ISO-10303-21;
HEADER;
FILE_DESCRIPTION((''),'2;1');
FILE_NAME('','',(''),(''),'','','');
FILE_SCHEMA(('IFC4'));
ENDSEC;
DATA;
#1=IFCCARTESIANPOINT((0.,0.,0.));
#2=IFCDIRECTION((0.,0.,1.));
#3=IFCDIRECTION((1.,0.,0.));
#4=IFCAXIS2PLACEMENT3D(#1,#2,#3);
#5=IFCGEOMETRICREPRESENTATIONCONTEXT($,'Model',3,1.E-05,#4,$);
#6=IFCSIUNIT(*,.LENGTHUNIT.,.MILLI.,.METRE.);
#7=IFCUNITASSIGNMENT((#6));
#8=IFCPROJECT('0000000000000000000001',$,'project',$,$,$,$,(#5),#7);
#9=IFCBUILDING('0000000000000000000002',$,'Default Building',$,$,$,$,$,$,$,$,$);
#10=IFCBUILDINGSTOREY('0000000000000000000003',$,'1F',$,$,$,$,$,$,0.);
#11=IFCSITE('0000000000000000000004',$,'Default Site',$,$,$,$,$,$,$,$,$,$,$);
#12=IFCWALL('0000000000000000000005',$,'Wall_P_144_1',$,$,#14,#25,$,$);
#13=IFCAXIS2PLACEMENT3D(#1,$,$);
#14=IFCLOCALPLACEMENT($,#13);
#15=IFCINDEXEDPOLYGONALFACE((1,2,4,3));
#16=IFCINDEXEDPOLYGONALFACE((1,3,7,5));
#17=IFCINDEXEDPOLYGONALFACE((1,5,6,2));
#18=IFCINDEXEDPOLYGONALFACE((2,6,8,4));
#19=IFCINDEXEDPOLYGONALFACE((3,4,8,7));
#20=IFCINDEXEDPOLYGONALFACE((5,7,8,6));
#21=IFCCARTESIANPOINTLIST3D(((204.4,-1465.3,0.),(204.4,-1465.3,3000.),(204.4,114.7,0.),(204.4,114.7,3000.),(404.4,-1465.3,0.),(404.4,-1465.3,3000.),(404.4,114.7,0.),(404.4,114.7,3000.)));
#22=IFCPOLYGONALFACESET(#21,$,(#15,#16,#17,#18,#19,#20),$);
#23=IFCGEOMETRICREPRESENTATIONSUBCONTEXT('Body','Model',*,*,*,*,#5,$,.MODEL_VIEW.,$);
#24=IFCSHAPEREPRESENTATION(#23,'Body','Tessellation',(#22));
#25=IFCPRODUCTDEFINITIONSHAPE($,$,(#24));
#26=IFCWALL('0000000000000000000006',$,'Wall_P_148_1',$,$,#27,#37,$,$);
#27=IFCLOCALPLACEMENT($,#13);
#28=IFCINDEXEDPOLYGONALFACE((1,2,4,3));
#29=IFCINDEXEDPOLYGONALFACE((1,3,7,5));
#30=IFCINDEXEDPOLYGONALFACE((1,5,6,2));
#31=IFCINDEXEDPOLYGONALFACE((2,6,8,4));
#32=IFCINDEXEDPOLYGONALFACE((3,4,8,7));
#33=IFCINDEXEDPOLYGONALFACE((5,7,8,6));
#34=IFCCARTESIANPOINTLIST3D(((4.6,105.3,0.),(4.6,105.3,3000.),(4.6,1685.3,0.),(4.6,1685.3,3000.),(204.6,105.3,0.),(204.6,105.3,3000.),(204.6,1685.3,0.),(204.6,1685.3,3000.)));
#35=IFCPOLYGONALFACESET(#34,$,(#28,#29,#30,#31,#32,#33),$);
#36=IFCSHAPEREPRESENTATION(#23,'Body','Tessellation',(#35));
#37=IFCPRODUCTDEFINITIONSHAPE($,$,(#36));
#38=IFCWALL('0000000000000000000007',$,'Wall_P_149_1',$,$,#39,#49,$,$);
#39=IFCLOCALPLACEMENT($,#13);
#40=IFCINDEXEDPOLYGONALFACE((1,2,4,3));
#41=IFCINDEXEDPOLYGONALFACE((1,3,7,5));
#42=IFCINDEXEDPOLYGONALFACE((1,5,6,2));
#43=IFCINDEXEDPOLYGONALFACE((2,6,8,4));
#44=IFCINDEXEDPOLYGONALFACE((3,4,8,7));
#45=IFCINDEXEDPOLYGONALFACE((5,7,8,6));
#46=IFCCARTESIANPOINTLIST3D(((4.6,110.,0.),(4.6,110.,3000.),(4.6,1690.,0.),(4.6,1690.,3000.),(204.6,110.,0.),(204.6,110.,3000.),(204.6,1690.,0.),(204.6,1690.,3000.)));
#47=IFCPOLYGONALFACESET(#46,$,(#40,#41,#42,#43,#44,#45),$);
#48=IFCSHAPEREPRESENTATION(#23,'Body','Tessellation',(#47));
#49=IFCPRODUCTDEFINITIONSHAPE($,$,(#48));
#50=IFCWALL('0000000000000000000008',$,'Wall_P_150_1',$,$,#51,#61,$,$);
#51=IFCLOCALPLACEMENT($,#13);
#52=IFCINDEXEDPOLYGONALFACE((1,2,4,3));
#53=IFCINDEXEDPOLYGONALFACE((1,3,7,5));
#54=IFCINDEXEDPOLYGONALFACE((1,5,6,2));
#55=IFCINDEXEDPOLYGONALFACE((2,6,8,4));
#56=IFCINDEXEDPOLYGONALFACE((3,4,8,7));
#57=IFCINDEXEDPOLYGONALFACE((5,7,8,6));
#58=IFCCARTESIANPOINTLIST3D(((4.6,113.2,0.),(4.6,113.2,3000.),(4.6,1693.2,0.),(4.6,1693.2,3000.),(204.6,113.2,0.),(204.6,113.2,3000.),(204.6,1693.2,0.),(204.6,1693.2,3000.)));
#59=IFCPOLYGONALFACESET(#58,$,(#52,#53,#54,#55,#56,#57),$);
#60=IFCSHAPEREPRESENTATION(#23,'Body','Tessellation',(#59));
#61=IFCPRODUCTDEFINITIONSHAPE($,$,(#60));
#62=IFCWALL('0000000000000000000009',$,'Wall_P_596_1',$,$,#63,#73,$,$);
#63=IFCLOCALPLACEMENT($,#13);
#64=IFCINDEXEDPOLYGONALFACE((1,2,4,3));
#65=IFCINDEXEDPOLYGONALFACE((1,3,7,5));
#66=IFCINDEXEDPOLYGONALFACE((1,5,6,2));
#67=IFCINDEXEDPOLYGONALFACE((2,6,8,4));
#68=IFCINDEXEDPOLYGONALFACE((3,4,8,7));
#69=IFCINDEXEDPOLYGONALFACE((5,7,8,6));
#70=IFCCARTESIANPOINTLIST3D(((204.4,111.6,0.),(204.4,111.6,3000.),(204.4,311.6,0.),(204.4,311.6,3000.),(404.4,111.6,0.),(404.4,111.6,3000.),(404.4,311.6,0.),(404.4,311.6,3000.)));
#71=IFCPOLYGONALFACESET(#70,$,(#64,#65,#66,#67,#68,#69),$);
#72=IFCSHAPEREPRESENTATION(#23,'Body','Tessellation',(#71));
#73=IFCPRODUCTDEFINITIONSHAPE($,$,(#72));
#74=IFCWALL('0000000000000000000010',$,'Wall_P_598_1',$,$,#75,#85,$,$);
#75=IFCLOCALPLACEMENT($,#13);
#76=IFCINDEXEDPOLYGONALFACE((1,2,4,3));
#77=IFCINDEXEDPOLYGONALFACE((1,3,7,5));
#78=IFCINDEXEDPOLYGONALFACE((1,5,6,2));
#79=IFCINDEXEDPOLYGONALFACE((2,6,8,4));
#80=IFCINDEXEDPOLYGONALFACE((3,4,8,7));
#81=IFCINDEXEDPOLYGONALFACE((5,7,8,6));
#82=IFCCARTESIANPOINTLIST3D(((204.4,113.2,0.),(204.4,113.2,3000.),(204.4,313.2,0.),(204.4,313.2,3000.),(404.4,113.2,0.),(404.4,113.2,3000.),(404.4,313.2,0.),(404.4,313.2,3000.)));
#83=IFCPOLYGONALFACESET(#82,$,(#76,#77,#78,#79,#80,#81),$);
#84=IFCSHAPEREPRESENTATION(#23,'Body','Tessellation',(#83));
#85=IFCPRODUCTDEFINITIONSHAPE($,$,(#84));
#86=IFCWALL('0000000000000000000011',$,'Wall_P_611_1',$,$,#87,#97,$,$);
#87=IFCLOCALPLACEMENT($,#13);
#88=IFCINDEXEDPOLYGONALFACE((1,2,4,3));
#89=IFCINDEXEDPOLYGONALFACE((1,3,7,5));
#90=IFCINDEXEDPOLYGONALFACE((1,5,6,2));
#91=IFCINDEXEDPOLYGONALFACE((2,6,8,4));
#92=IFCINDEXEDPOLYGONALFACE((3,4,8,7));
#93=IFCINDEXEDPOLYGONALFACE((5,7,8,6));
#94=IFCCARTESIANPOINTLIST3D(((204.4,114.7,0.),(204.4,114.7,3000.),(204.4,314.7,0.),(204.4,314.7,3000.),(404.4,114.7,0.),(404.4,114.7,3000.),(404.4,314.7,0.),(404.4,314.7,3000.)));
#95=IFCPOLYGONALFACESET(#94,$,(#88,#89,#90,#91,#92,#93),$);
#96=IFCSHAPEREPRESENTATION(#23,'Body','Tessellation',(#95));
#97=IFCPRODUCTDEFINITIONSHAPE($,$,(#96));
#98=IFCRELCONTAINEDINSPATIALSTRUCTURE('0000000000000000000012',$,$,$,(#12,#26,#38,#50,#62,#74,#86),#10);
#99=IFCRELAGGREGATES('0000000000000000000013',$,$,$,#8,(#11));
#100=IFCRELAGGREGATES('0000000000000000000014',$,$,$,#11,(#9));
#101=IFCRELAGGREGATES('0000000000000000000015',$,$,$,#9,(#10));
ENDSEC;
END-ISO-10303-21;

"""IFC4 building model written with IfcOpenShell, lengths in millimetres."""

from ifc_helpers import new_model, si_unit, frame, origin_with_axes, place, context, subcontext, project, spatial, indexed_curve, outline, extrude, element, save


model = new_model("IFC4")

# Units and contexts
model_context = context("Model", 3, precision=1e-05, world=origin_with_axes())
body_context = subcontext(model_context, "Body", "Model", "MODEL_VIEW")
ifc_project = project(units=[si_unit("LENGTHUNIT", "METRE", prefix="MILLI")], contexts=[model_context])

# Site, building, storey
site = spatial("IfcSite", under=ifc_project, Name="Default Site")
building = spatial("IfcBuilding", under=site, Name="Default Building")
storey = spatial("IfcBuildingStorey", under=building, Name="1F", Elevation=0.0)

# Walls
wall_1_placement = place(None, frame((204.4, 114.7, 0.0), z_axis=(0.0, 0.0, 1.0), x_axis=(0.0, -1.0, 0.0)))
element("IfcWall", 1, at=wall_1_placement, inside=storey, Name="Wall_P_144_1", context=body_context, shape_type="SweptSolid", body=[
    extrude(outline(indexed_curve([(0.0, 0.0), (0.0, 200.0), (1580.0, 200.0), (1580.0, 0.0), (0.0, 0.0)], self_intersect=False)), origin_with_axes(), (0.0, 0.0, 1.0), 3000.0),
])
wall_2_placement = place(None, frame((204.6, 105.3, 0.0), z_axis=(0.0, 0.0, 1.0), x_axis=(0.0, 1.0, 0.0)))
element("IfcWall", 2, at=wall_2_placement, inside=storey, Name="Wall_P_148_1", context=body_context, shape_type="SweptSolid", body=[
    extrude(outline(indexed_curve([(0.0, 0.0), (0.0, 200.0), (1580.0, 200.0), (1580.0, 0.0), (0.0, 0.0)], self_intersect=False)), origin_with_axes(), (0.0, 0.0, 1.0), 3000.0),
])
wall_3_placement = place(None, frame((204.6, 110.0, 0.0), z_axis=(0.0, 0.0, 1.0), x_axis=(0.0, 1.0, 0.0)))
element("IfcWall", 3, at=wall_3_placement, inside=storey, Name="Wall_P_149_1", context=body_context, shape_type="SweptSolid", body=[
    extrude(outline(indexed_curve([(0.0, 0.0), (0.0, 200.0), (1580.0, 200.0), (1580.0, 0.0), (0.0, 0.0)], self_intersect=False)), origin_with_axes(), (0.0, 0.0, 1.0), 3000.0),
])
wall_4_placement = place(None, frame((204.6, 113.2, 0.0), z_axis=(0.0, 0.0, 1.0), x_axis=(0.0, 1.0, 0.0)))
element("IfcWall", 4, at=wall_4_placement, inside=storey, Name="Wall_P_150_1", context=body_context, shape_type="SweptSolid", body=[
    extrude(outline(indexed_curve([(0.0, 0.0), (0.0, 200.0), (1580.0, 200.0), (1580.0, 0.0), (0.0, 0.0)], self_intersect=False)), origin_with_axes(), (0.0, 0.0, 1.0), 3000.0),
])
for number, where, z_axis, x_axis, name in (
    (5, (204.4, 111.6, 0.0), (0.0, 0.0, 1.0), (1.0, 0.0, 0.0), "Wall_P_596_1"),
    (6, (204.4, 113.2, 0.0), (0.0, 0.0, 1.0), (1.0, 0.0, 0.0), "Wall_P_598_1"),
    (7, (204.4, 114.7, 0.0), (0.0, 0.0, 1.0), (1.0, 0.0, 0.0), "Wall_P_611_1"),
):
    element("IfcWall", number, at=place(None, frame(where, z_axis=z_axis, x_axis=x_axis)), inside=storey, Name=name, context=body_context, shape_type="SweptSolid", body=[
        extrude(outline(indexed_curve([(0.0, 0.0), (0.0, 200.0), (200.0, 200.0), (200.0, 0.0), (0.0, 0.0)], self_intersect=False)), origin_with_axes(), (0.0, 0.0, 1.0), 3000.0),
    ])

save(model, "model.ifc")
